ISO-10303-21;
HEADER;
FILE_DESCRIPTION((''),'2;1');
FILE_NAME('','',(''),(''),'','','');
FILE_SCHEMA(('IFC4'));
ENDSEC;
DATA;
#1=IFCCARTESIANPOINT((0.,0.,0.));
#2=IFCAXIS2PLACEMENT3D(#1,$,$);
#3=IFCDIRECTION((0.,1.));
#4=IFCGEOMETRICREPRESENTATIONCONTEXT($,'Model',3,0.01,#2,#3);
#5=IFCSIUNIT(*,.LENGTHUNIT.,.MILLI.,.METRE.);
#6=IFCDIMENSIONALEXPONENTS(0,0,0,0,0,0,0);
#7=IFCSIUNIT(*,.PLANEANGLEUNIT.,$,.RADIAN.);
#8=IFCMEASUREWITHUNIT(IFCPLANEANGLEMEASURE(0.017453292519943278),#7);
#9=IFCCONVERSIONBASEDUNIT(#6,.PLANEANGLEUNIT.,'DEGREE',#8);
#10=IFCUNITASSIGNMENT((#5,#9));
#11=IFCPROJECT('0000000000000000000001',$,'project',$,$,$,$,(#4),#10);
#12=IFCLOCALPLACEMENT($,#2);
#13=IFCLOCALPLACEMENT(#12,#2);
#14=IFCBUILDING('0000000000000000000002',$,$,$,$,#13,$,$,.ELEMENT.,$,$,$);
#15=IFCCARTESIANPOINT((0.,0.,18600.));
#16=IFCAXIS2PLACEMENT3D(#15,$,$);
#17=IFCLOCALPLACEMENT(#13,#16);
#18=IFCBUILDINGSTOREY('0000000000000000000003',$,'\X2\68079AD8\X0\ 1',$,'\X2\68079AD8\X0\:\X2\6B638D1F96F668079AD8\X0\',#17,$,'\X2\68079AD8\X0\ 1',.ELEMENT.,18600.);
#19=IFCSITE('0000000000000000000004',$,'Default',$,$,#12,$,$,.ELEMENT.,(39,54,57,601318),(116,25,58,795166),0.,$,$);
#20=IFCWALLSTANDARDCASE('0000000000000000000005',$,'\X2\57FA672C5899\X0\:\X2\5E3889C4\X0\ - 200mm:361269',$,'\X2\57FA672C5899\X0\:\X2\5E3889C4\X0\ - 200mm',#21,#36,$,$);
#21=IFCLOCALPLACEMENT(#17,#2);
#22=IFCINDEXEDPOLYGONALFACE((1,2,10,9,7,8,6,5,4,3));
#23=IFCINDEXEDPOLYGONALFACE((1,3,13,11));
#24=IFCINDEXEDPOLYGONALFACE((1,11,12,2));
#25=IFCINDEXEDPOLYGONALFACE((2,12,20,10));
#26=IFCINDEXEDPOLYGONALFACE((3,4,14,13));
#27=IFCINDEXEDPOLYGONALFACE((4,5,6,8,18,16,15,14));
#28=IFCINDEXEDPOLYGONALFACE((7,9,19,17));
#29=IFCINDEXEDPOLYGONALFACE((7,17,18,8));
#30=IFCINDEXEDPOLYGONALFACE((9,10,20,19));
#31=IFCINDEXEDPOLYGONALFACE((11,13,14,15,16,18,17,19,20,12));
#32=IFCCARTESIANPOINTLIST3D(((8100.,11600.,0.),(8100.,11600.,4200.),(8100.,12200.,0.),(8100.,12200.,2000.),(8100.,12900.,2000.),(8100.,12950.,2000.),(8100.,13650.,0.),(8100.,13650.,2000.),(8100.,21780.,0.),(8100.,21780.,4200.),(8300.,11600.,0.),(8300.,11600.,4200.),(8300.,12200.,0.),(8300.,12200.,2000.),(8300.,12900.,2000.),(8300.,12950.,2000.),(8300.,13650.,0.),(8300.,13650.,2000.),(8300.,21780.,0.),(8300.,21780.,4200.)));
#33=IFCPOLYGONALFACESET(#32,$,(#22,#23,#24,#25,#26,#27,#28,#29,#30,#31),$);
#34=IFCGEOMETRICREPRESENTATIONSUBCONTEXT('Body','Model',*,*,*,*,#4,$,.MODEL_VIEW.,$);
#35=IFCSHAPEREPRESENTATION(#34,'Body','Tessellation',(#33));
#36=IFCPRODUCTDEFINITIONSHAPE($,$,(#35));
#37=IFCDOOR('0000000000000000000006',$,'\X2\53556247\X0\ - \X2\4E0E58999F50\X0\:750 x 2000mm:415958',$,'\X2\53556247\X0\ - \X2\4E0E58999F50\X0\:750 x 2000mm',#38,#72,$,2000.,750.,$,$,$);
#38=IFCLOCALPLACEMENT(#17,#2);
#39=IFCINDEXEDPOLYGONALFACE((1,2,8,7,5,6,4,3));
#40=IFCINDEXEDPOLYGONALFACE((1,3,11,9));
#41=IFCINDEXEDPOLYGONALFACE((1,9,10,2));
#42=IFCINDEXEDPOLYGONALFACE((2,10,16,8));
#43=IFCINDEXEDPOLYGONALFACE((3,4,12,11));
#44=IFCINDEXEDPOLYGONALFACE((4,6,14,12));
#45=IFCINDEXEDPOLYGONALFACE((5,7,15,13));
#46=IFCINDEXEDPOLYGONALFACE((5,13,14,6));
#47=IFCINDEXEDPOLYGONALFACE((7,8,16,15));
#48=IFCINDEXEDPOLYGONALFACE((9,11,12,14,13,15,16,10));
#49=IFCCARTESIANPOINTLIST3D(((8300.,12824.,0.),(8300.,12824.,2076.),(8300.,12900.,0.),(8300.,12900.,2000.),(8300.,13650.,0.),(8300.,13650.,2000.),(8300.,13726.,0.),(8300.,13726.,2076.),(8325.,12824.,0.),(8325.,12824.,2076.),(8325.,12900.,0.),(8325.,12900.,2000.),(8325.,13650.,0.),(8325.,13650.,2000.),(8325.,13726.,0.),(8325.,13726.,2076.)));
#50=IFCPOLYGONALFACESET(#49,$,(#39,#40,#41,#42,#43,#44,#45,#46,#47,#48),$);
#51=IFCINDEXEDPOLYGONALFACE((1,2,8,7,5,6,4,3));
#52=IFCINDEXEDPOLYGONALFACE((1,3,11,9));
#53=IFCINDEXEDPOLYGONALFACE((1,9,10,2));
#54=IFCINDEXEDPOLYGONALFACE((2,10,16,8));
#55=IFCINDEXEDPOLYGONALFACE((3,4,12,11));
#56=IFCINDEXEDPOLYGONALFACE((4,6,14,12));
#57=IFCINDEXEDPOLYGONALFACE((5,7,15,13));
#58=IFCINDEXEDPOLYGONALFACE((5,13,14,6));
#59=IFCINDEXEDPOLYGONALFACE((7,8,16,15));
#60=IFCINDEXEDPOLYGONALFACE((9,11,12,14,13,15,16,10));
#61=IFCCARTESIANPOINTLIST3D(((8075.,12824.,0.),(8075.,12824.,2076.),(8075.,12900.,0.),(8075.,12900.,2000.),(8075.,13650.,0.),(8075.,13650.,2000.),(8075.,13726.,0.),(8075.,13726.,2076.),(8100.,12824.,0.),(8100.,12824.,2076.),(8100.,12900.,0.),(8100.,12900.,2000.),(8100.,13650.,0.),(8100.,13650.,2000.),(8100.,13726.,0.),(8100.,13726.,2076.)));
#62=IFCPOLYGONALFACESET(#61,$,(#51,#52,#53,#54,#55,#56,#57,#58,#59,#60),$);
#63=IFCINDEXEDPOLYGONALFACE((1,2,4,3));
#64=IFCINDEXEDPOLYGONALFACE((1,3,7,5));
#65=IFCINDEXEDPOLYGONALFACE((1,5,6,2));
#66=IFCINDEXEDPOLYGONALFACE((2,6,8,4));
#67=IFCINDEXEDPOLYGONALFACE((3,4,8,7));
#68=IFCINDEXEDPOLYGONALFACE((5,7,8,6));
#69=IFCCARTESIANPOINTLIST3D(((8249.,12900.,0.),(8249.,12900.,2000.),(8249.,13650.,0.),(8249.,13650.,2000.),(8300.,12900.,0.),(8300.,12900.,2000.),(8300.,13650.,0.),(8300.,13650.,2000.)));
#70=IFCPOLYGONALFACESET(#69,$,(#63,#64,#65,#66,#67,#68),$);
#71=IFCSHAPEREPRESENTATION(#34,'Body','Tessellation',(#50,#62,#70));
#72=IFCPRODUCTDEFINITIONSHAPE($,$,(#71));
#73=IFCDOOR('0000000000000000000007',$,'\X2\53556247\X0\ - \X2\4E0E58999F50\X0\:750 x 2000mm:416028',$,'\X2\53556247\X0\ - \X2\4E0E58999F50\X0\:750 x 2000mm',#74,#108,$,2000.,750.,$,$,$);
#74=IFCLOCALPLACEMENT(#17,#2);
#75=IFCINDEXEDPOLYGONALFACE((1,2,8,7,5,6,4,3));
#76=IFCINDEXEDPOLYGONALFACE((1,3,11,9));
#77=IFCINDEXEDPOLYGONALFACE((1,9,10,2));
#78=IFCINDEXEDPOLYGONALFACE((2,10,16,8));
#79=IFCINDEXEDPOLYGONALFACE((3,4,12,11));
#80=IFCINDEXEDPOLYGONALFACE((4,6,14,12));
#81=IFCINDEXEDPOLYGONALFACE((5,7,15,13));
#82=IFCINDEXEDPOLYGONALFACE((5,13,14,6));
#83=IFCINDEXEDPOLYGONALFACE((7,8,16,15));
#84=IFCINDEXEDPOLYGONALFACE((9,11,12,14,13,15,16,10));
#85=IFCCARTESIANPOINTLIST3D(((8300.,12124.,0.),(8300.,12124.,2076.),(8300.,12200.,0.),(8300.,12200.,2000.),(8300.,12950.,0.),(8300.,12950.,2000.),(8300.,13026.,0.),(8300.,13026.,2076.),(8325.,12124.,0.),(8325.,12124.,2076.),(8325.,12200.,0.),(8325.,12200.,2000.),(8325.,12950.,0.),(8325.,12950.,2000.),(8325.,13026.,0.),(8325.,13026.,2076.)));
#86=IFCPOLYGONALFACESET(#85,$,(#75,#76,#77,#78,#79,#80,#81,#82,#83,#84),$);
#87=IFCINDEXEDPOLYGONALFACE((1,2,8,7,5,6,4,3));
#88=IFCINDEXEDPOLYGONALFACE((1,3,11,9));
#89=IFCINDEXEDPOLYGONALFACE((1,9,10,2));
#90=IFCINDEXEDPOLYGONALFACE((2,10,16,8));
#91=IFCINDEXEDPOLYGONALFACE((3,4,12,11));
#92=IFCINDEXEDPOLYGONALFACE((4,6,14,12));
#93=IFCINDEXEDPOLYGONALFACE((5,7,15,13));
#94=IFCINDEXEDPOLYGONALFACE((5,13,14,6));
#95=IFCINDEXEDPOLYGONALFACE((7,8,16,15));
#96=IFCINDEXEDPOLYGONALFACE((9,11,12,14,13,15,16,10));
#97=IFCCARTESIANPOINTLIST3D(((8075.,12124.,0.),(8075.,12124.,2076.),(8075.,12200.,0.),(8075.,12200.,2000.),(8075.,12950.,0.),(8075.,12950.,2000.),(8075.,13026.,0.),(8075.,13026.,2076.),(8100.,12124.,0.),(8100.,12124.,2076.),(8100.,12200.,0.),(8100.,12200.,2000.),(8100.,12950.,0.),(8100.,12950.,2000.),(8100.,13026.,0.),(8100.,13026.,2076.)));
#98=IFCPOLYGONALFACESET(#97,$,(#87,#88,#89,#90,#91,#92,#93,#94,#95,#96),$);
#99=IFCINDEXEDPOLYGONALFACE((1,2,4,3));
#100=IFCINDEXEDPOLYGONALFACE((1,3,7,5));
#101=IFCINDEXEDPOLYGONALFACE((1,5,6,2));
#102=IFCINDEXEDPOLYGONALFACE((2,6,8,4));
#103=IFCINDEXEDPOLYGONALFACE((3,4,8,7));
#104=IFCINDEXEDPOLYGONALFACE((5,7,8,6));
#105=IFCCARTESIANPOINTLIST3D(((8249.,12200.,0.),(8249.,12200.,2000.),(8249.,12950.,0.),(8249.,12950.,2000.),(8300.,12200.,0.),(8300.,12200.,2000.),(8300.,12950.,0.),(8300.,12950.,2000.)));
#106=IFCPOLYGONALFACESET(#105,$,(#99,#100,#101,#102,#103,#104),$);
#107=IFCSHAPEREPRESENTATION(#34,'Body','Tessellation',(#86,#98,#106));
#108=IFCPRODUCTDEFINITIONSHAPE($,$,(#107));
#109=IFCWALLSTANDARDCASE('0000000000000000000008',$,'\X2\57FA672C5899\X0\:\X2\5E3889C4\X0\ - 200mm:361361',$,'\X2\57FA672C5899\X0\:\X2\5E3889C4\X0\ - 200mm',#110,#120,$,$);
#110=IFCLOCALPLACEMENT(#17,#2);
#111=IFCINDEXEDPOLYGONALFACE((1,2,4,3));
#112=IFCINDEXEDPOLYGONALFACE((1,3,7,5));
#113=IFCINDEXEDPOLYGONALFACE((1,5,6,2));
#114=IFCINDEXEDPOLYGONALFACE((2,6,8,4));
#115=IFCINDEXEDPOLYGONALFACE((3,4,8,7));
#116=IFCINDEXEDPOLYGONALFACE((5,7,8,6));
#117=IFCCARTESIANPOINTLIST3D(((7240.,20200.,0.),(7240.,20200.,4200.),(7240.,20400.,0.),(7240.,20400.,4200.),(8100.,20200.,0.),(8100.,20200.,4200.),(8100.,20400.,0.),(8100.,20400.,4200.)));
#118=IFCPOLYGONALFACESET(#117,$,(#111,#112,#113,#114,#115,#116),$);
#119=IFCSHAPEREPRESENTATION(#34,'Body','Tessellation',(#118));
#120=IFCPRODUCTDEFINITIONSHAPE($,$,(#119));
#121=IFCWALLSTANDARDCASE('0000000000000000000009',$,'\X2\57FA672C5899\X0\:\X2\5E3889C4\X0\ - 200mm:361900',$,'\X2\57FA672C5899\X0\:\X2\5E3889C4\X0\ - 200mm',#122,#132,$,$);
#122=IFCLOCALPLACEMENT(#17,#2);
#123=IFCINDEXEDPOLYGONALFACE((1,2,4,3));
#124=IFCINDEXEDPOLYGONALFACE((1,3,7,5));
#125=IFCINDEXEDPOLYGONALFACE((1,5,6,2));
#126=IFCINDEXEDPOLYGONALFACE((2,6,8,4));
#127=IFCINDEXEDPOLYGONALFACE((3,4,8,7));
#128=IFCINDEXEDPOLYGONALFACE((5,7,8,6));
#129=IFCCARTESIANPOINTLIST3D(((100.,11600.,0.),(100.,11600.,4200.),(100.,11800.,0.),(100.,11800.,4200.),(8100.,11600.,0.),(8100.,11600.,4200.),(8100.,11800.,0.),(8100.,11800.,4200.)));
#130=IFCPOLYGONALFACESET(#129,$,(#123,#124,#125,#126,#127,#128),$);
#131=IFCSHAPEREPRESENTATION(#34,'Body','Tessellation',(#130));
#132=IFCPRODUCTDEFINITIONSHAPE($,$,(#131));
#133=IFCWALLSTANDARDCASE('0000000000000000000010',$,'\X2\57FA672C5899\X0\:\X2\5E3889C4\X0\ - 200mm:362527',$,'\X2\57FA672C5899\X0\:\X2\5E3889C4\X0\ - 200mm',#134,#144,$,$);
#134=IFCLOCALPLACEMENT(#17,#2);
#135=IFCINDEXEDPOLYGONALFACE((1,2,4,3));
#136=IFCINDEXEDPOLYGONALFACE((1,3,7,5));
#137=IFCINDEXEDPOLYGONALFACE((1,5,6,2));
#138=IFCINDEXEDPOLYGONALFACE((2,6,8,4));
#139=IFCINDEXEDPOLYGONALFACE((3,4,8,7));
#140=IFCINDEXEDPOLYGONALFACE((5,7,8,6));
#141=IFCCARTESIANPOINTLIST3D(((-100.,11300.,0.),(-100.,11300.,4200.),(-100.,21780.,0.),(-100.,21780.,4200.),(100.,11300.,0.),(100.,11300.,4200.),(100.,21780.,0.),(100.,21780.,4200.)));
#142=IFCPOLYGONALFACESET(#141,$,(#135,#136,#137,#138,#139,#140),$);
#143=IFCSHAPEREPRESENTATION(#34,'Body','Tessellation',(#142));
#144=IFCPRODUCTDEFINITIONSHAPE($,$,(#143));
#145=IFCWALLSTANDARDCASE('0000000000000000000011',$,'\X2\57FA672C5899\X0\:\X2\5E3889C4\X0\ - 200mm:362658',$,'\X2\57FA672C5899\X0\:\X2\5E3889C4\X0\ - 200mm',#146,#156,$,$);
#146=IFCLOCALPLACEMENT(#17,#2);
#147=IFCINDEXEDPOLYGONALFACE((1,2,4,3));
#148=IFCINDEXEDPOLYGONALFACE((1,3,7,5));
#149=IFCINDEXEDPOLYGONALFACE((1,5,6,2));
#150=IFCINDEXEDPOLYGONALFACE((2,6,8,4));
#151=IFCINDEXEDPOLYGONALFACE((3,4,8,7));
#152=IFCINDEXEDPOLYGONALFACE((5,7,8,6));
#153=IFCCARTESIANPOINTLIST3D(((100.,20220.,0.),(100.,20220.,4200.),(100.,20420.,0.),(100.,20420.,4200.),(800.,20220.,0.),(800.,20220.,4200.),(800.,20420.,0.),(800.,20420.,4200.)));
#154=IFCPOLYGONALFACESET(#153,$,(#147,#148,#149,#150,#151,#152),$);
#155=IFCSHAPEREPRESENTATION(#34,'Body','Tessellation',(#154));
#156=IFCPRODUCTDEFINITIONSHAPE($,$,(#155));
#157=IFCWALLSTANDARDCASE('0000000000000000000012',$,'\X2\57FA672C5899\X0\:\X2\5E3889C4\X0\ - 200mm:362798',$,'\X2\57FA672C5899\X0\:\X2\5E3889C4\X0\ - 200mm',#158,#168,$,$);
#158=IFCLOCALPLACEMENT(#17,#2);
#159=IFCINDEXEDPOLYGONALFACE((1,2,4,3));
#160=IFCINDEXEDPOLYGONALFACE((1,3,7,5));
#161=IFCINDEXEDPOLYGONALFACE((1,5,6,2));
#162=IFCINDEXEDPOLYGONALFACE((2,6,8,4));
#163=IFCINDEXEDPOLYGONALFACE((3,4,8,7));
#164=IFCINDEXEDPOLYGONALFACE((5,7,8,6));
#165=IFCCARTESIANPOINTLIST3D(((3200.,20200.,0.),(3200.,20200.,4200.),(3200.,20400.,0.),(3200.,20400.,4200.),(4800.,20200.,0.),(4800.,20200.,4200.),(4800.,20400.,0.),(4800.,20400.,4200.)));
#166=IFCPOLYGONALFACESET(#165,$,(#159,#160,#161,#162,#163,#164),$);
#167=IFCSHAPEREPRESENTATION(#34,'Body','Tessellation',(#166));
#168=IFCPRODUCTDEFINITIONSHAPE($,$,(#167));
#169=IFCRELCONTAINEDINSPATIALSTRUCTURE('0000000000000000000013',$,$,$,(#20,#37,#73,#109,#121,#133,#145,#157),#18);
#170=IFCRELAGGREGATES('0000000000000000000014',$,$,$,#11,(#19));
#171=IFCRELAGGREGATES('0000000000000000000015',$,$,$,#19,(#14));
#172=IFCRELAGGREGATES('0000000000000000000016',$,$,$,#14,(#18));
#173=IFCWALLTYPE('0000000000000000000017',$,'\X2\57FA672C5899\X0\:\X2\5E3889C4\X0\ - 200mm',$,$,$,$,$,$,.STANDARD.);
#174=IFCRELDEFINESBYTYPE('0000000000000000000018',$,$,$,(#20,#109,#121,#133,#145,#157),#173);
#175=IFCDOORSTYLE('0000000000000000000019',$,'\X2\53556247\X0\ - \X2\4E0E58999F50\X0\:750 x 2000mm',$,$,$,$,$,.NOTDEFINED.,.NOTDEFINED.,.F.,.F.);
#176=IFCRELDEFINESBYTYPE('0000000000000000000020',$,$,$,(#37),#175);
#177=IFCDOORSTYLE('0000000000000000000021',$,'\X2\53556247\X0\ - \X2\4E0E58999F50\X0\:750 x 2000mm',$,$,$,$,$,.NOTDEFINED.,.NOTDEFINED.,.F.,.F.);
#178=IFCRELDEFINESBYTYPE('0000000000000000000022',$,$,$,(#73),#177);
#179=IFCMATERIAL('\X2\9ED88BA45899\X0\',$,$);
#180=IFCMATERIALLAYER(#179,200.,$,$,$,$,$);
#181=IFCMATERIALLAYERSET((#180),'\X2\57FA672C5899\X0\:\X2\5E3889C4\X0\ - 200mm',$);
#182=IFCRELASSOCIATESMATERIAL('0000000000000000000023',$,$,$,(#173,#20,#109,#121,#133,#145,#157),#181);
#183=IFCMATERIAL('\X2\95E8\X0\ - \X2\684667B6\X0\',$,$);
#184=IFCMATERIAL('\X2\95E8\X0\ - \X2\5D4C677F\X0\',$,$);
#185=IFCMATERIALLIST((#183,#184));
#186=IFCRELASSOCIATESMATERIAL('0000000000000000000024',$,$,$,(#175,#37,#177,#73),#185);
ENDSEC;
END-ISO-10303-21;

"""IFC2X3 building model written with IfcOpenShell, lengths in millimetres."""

from ifc_helpers import new_model, entity, si_unit, converted_unit, direction, frame, frame_2d, origin, place, context, subcontext, project, spatial, polyline, rectangle, outline, extrude, source, transform, mapped, material, material_list, layer, layer_set, layer_usage, type_object, type_shapes, element, fill, save


model = new_model("IFC2X3")

# Units and contexts
model_context = context("Model", 3, precision=0.01, world=origin(), true_north=direction((0.0, 1.0)))
body_context = subcontext(model_context, "Body", "Model", "MODEL_VIEW")
ifc_project = project(units=[si_unit("LENGTHUNIT", "METRE", prefix="MILLI"), converted_unit("PLANEANGLEUNIT", "DEGREE", entity("IfcPlaneAngleMeasure", 0.017453292519943278), si_unit("PLANEANGLEUNIT", "RADIAN"), dimensions=[0, 0, 0, 0, 0, 0, 0])], contexts=[model_context])

# Site, building, storey
site_placement = place(None, origin())
site = spatial("IfcSite", under=ifc_project, at=site_placement, Name="Default", CompositionType="ELEMENT", RefLatitude=(39, 54, 57, 601318), RefLongitude=(116, 25, 58, 795166), RefElevation=0.0)
building_placement = place(site_placement, origin())
building = spatial("IfcBuilding", under=site, at=building_placement, CompositionType="ELEMENT")
storey_placement = place(building_placement, frame((0.0, 0.0, 18600.0)))
storey = spatial("IfcBuildingStorey", under=building, at=storey_placement, Name="标高 1", ObjectType="标高:正负零标高", LongName="标高 1", CompositionType="ELEMENT", Elevation=18600.0)

# Wall, openings, doors
ifc_material_1 = material(Name="默认墙")
ifc_layer = layer(ifc_material_1, 200.0)
ifc_layer_set = layer_set([ifc_layer], Name="基本墙:常规 - 200mm")
ifc_layer_usage_1 = layer_usage(ifc_layer_set, "AXIS2", "NEGATIVE", 100.0)
wall_type = type_object("IfcWallType", Name="基本墙:常规 - 200mm", PredefinedType="STANDARD", material=ifc_layer_set)
wall_1_placement = place(storey_placement, frame((8200.0, 21780.0, 0.0), z_axis=(0.0, 0.0, 1.0), x_axis=(0.0, -1.0, 0.0)))
wall_1 = element("IfcWallStandardCase", 1, at=wall_1_placement, inside=storey, type_object=wall_type, material=ifc_layer_usage_1, Name="基本墙:常规 - 200mm:361269", ObjectType="基本墙:常规 - 200mm", context=body_context, shape_type="SweptSolid", body=[
    extrude(rectangle(XDim=10180.0, YDim=200.0, at=frame_2d((5090.0, 0.0), x_axis=(-1.0, 0.0))), origin(), (0.0, 0.0, 1.0), 4200.0),
])
opening_1_placement = place(wall_1_placement, frame((8130.0, -100.0, 0.0)))
opening_1 = element("IfcOpeningElement", 2, at=opening_1_placement, cuts=wall_1, ObjectType="Opening", context=body_context, shape_type="SweptSolid", body=[
    extrude(rectangle(XDim=750.0, YDim=2000.0, at=frame_2d((1000.0, 375.0), x_axis=(0.0, -1.0))), frame((0.0, 0.0, 0.0), z_axis=(0.0, 1.0, 0.0), x_axis=(0.0, 0.0, 1.0)), (0.0, 0.0, 1.0), 200.0),
])
opening_2_placement = place(wall_1_placement, frame((8830.0, -100.0, 0.0)))
opening_2 = element("IfcOpeningElement", 3, at=opening_2_placement, cuts=wall_1, ObjectType="Opening", context=body_context, shape_type="SweptSolid", body=[
    extrude(rectangle(XDim=750.0, YDim=2000.0, at=frame_2d((1000.0, 375.0), x_axis=(0.0, 1.0))), frame((0.0, 0.0, 0.0), z_axis=(0.0, 1.0, 0.0), x_axis=(0.0, 0.0, 1.0)), (0.0, 0.0, 1.0), 200.0),
])
ifc_material_2 = material(Name="门 - 框架")
ifc_material_3 = material(Name="门 - 嵌板")
ifc_material_list = material_list([ifc_material_2, ifc_material_3])
door_style_1 = type_object("IfcDoorStyle", Name="单扇 - 与墙齐:750 x 2000mm", ConstructionType="NOTDEFINED", OperationType="NOTDEFINED", ParameterTakesPrecedence=False, Sizeable=False, material=ifc_material_list)
shared_shape_1 = source(origin(), body_context, "Body", "SweptSolid", [
    extrude(outline(polyline([(-451.0, -1057.0), (451.0, -1057.0), (451.0, 1019.0), (375.0, 1019.0), (375.0, -981.0), (-375.0, -981.0), (-375.0, 1019.0), (-451.0, 1019.0), (-451.0, -1057.0)])), frame((375.0, 225.0, 1019.0), z_axis=(0.0, -1.0, 0.0), x_axis=(-1.0, 0.0, 0.0)), (0.0, 0.0, 1.0), 25.0),
    extrude(outline(polyline([(-1057.0, -451.0), (1019.0, -451.0), (1019.0, -375.0), (-981.0, -375.0), (-981.0, 375.0), (1019.0, 375.0), (1019.0, 451.0), (-1057.0, 451.0), (-1057.0, -451.0)])), frame((375.0, 0.0, 1019.0), z_axis=(0.0, -1.0, 0.0), x_axis=(0.0, 0.0, -1.0)), (0.0, 0.0, 1.0), 25.0),
    extrude(rectangle(XDim=750.0, YDim=51.0, at=frame_2d((0.0, 0.0), x_axis=(1.0, 0.0))), frame((375.0, 174.5, 0.0)), (0.0, 0.0, 1.0), 2000.0),
])
type_shapes(door_style_1, [shared_shape_1])
door_1_placement = place(opening_1_placement, origin())
door_1 = element("IfcDoor", 4, at=door_1_placement, inside=storey, type_object=door_style_1, material=ifc_material_list, Name="单扇 - 与墙齐:750 x 2000mm:415958", ObjectType="单扇 - 与墙齐:750 x 2000mm", OverallHeight=2000.0, OverallWidth=750.0, context=body_context, shape_type="MappedRepresentation", body=[
    mapped(shared_shape_1, transform((0.0, 0.0, 0.0), scale=1.0)),
])
fill(opening_1, door_1)
door_style_2 = type_object("IfcDoorStyle", Name="单扇 - 与墙齐:750 x 2000mm", ConstructionType="NOTDEFINED", OperationType="NOTDEFINED", ParameterTakesPrecedence=False, Sizeable=False, material=ifc_material_list)
shared_shape_2 = source(origin(), body_context, "Body", "SweptSolid", [
    extrude(outline(polyline([(-451.0, -1057.0), (451.0, -1057.0), (451.0, 1019.0), (375.0, 1019.0), (375.0, -981.0), (-375.0, -981.0), (-375.0, 1019.0), (-451.0, 1019.0), (-451.0, -1057.0)])), frame((375.0, 200.0, 1019.0), z_axis=(0.0, 1.0, 0.0), x_axis=(1.0, 0.0, 0.0)), (0.0, 0.0, 1.0), 25.0),
    extrude(outline(polyline([(-1057.0, -451.0), (1019.0, -451.0), (1019.0, -375.0), (-981.0, -375.0), (-981.0, 375.0), (1019.0, 375.0), (1019.0, 451.0), (-1057.0, 451.0), (-1057.0, -451.0)])), frame((375.0, -25.0, 1019.0), z_axis=(0.0, 1.0, 0.0), x_axis=(0.0, 0.0, -1.0)), (0.0, 0.0, 1.0), 25.0),
    extrude(rectangle(XDim=51.0, YDim=750.0, at=frame_2d((0.0, 0.0), x_axis=(1.0, 0.0))), frame((375.0, 174.5, 0.0), z_axis=(0.0, 0.0, 1.0), x_axis=(0.0, 1.0, 0.0)), (0.0, 0.0, 1.0), 2000.0),
])
type_shapes(door_style_2, [shared_shape_2])
door_2_placement = place(opening_2_placement, origin())
door_2 = element("IfcDoor", 5, at=door_2_placement, inside=storey, type_object=door_style_2, material=ifc_material_list, Name="单扇 - 与墙齐:750 x 2000mm:416028", ObjectType="单扇 - 与墙齐:750 x 2000mm", OverallHeight=2000.0, OverallWidth=750.0, context=body_context, shape_type="MappedRepresentation", body=[
    mapped(shared_shape_2, transform((0.0, 0.0, 0.0), scale=1.0)),
])
fill(opening_2, door_2)

# Walls
ifc_layer_usage_2 = layer_usage(ifc_layer_set, "AXIS2", "NEGATIVE", 100.0)
wall_2_placement = place(storey_placement, frame((8100.0, 20300.0, 0.0), z_axis=(0.0, 0.0, 1.0), x_axis=(-1.0, 0.0, 0.0)))
element("IfcWallStandardCase", 6, at=wall_2_placement, inside=storey, type_object=wall_type, material=ifc_layer_usage_2, Name="基本墙:常规 - 200mm:361361", ObjectType="基本墙:常规 - 200mm", context=body_context, shape_type="SweptSolid", body=[
    extrude(rectangle(XDim=860.0, YDim=200.0, at=frame_2d((430.0, 0.0), x_axis=(-1.0, 0.0))), origin(), (0.0, 0.0, 1.0), 4200.0),
])
ifc_layer_usage_3 = layer_usage(ifc_layer_set, "AXIS2", "NEGATIVE", 100.0)
wall_3_placement = place(storey_placement, frame((8100.0, 11700.0, 0.0), z_axis=(0.0, 0.0, 1.0), x_axis=(-1.0, 0.0, 0.0)))
element("IfcWallStandardCase", 7, at=wall_3_placement, inside=storey, type_object=wall_type, material=ifc_layer_usage_3, Name="基本墙:常规 - 200mm:361900", ObjectType="基本墙:常规 - 200mm", context=body_context, shape_type="SweptSolid", body=[
    extrude(rectangle(XDim=8000.0, YDim=200.0, at=frame_2d((4000.0, 0.0), x_axis=(-1.0, 0.0))), origin(), (0.0, 0.0, 1.0), 4200.0),
])
ifc_layer_usage_4 = layer_usage(ifc_layer_set, "AXIS2", "NEGATIVE", 100.0)
wall_4_placement = place(storey_placement, frame((0.0, 11300.0, 0.0), z_axis=(0.0, 0.0, 1.0), x_axis=(0.0, 1.0, 0.0)))
element("IfcWallStandardCase", 8, at=wall_4_placement, inside=storey, type_object=wall_type, material=ifc_layer_usage_4, Name="基本墙:常规 - 200mm:362527", ObjectType="基本墙:常规 - 200mm", context=body_context, shape_type="SweptSolid", body=[
    extrude(rectangle(XDim=10480.0, YDim=200.0, at=frame_2d((5240.0, 0.0), x_axis=(-1.0, 0.0))), origin(), (0.0, 0.0, 1.0), 4200.0),
])
ifc_layer_usage_5 = layer_usage(ifc_layer_set, "AXIS2", "NEGATIVE", 100.0)
wall_5_placement = place(storey_placement, frame((100.0, 20320.0, 0.0)))
element("IfcWallStandardCase", 9, at=wall_5_placement, inside=storey, type_object=wall_type, material=ifc_layer_usage_5, Name="基本墙:常规 - 200mm:362658", ObjectType="基本墙:常规 - 200mm", context=body_context, shape_type="SweptSolid", body=[
    extrude(rectangle(XDim=700.0, YDim=200.0, at=frame_2d((350.0, 0.0), x_axis=(-1.0, 0.0))), origin(), (0.0, 0.0, 1.0), 4200.0),
])
ifc_layer_usage_6 = layer_usage(ifc_layer_set, "AXIS2", "NEGATIVE", 100.0)
wall_6_placement = place(storey_placement, frame((3200.0, 20300.0, 0.0)))
element("IfcWallStandardCase", 10, at=wall_6_placement, inside=storey, type_object=wall_type, material=ifc_layer_usage_6, Name="基本墙:常规 - 200mm:362798", ObjectType="基本墙:常规 - 200mm", context=body_context, shape_type="SweptSolid", body=[
    extrude(rectangle(XDim=1600.0, YDim=200.0, at=frame_2d((800.0, 0.0), x_axis=(-1.0, 0.0))), origin(), (0.0, 0.0, 1.0), 4200.0),
])

save(model, "model.ifc")
